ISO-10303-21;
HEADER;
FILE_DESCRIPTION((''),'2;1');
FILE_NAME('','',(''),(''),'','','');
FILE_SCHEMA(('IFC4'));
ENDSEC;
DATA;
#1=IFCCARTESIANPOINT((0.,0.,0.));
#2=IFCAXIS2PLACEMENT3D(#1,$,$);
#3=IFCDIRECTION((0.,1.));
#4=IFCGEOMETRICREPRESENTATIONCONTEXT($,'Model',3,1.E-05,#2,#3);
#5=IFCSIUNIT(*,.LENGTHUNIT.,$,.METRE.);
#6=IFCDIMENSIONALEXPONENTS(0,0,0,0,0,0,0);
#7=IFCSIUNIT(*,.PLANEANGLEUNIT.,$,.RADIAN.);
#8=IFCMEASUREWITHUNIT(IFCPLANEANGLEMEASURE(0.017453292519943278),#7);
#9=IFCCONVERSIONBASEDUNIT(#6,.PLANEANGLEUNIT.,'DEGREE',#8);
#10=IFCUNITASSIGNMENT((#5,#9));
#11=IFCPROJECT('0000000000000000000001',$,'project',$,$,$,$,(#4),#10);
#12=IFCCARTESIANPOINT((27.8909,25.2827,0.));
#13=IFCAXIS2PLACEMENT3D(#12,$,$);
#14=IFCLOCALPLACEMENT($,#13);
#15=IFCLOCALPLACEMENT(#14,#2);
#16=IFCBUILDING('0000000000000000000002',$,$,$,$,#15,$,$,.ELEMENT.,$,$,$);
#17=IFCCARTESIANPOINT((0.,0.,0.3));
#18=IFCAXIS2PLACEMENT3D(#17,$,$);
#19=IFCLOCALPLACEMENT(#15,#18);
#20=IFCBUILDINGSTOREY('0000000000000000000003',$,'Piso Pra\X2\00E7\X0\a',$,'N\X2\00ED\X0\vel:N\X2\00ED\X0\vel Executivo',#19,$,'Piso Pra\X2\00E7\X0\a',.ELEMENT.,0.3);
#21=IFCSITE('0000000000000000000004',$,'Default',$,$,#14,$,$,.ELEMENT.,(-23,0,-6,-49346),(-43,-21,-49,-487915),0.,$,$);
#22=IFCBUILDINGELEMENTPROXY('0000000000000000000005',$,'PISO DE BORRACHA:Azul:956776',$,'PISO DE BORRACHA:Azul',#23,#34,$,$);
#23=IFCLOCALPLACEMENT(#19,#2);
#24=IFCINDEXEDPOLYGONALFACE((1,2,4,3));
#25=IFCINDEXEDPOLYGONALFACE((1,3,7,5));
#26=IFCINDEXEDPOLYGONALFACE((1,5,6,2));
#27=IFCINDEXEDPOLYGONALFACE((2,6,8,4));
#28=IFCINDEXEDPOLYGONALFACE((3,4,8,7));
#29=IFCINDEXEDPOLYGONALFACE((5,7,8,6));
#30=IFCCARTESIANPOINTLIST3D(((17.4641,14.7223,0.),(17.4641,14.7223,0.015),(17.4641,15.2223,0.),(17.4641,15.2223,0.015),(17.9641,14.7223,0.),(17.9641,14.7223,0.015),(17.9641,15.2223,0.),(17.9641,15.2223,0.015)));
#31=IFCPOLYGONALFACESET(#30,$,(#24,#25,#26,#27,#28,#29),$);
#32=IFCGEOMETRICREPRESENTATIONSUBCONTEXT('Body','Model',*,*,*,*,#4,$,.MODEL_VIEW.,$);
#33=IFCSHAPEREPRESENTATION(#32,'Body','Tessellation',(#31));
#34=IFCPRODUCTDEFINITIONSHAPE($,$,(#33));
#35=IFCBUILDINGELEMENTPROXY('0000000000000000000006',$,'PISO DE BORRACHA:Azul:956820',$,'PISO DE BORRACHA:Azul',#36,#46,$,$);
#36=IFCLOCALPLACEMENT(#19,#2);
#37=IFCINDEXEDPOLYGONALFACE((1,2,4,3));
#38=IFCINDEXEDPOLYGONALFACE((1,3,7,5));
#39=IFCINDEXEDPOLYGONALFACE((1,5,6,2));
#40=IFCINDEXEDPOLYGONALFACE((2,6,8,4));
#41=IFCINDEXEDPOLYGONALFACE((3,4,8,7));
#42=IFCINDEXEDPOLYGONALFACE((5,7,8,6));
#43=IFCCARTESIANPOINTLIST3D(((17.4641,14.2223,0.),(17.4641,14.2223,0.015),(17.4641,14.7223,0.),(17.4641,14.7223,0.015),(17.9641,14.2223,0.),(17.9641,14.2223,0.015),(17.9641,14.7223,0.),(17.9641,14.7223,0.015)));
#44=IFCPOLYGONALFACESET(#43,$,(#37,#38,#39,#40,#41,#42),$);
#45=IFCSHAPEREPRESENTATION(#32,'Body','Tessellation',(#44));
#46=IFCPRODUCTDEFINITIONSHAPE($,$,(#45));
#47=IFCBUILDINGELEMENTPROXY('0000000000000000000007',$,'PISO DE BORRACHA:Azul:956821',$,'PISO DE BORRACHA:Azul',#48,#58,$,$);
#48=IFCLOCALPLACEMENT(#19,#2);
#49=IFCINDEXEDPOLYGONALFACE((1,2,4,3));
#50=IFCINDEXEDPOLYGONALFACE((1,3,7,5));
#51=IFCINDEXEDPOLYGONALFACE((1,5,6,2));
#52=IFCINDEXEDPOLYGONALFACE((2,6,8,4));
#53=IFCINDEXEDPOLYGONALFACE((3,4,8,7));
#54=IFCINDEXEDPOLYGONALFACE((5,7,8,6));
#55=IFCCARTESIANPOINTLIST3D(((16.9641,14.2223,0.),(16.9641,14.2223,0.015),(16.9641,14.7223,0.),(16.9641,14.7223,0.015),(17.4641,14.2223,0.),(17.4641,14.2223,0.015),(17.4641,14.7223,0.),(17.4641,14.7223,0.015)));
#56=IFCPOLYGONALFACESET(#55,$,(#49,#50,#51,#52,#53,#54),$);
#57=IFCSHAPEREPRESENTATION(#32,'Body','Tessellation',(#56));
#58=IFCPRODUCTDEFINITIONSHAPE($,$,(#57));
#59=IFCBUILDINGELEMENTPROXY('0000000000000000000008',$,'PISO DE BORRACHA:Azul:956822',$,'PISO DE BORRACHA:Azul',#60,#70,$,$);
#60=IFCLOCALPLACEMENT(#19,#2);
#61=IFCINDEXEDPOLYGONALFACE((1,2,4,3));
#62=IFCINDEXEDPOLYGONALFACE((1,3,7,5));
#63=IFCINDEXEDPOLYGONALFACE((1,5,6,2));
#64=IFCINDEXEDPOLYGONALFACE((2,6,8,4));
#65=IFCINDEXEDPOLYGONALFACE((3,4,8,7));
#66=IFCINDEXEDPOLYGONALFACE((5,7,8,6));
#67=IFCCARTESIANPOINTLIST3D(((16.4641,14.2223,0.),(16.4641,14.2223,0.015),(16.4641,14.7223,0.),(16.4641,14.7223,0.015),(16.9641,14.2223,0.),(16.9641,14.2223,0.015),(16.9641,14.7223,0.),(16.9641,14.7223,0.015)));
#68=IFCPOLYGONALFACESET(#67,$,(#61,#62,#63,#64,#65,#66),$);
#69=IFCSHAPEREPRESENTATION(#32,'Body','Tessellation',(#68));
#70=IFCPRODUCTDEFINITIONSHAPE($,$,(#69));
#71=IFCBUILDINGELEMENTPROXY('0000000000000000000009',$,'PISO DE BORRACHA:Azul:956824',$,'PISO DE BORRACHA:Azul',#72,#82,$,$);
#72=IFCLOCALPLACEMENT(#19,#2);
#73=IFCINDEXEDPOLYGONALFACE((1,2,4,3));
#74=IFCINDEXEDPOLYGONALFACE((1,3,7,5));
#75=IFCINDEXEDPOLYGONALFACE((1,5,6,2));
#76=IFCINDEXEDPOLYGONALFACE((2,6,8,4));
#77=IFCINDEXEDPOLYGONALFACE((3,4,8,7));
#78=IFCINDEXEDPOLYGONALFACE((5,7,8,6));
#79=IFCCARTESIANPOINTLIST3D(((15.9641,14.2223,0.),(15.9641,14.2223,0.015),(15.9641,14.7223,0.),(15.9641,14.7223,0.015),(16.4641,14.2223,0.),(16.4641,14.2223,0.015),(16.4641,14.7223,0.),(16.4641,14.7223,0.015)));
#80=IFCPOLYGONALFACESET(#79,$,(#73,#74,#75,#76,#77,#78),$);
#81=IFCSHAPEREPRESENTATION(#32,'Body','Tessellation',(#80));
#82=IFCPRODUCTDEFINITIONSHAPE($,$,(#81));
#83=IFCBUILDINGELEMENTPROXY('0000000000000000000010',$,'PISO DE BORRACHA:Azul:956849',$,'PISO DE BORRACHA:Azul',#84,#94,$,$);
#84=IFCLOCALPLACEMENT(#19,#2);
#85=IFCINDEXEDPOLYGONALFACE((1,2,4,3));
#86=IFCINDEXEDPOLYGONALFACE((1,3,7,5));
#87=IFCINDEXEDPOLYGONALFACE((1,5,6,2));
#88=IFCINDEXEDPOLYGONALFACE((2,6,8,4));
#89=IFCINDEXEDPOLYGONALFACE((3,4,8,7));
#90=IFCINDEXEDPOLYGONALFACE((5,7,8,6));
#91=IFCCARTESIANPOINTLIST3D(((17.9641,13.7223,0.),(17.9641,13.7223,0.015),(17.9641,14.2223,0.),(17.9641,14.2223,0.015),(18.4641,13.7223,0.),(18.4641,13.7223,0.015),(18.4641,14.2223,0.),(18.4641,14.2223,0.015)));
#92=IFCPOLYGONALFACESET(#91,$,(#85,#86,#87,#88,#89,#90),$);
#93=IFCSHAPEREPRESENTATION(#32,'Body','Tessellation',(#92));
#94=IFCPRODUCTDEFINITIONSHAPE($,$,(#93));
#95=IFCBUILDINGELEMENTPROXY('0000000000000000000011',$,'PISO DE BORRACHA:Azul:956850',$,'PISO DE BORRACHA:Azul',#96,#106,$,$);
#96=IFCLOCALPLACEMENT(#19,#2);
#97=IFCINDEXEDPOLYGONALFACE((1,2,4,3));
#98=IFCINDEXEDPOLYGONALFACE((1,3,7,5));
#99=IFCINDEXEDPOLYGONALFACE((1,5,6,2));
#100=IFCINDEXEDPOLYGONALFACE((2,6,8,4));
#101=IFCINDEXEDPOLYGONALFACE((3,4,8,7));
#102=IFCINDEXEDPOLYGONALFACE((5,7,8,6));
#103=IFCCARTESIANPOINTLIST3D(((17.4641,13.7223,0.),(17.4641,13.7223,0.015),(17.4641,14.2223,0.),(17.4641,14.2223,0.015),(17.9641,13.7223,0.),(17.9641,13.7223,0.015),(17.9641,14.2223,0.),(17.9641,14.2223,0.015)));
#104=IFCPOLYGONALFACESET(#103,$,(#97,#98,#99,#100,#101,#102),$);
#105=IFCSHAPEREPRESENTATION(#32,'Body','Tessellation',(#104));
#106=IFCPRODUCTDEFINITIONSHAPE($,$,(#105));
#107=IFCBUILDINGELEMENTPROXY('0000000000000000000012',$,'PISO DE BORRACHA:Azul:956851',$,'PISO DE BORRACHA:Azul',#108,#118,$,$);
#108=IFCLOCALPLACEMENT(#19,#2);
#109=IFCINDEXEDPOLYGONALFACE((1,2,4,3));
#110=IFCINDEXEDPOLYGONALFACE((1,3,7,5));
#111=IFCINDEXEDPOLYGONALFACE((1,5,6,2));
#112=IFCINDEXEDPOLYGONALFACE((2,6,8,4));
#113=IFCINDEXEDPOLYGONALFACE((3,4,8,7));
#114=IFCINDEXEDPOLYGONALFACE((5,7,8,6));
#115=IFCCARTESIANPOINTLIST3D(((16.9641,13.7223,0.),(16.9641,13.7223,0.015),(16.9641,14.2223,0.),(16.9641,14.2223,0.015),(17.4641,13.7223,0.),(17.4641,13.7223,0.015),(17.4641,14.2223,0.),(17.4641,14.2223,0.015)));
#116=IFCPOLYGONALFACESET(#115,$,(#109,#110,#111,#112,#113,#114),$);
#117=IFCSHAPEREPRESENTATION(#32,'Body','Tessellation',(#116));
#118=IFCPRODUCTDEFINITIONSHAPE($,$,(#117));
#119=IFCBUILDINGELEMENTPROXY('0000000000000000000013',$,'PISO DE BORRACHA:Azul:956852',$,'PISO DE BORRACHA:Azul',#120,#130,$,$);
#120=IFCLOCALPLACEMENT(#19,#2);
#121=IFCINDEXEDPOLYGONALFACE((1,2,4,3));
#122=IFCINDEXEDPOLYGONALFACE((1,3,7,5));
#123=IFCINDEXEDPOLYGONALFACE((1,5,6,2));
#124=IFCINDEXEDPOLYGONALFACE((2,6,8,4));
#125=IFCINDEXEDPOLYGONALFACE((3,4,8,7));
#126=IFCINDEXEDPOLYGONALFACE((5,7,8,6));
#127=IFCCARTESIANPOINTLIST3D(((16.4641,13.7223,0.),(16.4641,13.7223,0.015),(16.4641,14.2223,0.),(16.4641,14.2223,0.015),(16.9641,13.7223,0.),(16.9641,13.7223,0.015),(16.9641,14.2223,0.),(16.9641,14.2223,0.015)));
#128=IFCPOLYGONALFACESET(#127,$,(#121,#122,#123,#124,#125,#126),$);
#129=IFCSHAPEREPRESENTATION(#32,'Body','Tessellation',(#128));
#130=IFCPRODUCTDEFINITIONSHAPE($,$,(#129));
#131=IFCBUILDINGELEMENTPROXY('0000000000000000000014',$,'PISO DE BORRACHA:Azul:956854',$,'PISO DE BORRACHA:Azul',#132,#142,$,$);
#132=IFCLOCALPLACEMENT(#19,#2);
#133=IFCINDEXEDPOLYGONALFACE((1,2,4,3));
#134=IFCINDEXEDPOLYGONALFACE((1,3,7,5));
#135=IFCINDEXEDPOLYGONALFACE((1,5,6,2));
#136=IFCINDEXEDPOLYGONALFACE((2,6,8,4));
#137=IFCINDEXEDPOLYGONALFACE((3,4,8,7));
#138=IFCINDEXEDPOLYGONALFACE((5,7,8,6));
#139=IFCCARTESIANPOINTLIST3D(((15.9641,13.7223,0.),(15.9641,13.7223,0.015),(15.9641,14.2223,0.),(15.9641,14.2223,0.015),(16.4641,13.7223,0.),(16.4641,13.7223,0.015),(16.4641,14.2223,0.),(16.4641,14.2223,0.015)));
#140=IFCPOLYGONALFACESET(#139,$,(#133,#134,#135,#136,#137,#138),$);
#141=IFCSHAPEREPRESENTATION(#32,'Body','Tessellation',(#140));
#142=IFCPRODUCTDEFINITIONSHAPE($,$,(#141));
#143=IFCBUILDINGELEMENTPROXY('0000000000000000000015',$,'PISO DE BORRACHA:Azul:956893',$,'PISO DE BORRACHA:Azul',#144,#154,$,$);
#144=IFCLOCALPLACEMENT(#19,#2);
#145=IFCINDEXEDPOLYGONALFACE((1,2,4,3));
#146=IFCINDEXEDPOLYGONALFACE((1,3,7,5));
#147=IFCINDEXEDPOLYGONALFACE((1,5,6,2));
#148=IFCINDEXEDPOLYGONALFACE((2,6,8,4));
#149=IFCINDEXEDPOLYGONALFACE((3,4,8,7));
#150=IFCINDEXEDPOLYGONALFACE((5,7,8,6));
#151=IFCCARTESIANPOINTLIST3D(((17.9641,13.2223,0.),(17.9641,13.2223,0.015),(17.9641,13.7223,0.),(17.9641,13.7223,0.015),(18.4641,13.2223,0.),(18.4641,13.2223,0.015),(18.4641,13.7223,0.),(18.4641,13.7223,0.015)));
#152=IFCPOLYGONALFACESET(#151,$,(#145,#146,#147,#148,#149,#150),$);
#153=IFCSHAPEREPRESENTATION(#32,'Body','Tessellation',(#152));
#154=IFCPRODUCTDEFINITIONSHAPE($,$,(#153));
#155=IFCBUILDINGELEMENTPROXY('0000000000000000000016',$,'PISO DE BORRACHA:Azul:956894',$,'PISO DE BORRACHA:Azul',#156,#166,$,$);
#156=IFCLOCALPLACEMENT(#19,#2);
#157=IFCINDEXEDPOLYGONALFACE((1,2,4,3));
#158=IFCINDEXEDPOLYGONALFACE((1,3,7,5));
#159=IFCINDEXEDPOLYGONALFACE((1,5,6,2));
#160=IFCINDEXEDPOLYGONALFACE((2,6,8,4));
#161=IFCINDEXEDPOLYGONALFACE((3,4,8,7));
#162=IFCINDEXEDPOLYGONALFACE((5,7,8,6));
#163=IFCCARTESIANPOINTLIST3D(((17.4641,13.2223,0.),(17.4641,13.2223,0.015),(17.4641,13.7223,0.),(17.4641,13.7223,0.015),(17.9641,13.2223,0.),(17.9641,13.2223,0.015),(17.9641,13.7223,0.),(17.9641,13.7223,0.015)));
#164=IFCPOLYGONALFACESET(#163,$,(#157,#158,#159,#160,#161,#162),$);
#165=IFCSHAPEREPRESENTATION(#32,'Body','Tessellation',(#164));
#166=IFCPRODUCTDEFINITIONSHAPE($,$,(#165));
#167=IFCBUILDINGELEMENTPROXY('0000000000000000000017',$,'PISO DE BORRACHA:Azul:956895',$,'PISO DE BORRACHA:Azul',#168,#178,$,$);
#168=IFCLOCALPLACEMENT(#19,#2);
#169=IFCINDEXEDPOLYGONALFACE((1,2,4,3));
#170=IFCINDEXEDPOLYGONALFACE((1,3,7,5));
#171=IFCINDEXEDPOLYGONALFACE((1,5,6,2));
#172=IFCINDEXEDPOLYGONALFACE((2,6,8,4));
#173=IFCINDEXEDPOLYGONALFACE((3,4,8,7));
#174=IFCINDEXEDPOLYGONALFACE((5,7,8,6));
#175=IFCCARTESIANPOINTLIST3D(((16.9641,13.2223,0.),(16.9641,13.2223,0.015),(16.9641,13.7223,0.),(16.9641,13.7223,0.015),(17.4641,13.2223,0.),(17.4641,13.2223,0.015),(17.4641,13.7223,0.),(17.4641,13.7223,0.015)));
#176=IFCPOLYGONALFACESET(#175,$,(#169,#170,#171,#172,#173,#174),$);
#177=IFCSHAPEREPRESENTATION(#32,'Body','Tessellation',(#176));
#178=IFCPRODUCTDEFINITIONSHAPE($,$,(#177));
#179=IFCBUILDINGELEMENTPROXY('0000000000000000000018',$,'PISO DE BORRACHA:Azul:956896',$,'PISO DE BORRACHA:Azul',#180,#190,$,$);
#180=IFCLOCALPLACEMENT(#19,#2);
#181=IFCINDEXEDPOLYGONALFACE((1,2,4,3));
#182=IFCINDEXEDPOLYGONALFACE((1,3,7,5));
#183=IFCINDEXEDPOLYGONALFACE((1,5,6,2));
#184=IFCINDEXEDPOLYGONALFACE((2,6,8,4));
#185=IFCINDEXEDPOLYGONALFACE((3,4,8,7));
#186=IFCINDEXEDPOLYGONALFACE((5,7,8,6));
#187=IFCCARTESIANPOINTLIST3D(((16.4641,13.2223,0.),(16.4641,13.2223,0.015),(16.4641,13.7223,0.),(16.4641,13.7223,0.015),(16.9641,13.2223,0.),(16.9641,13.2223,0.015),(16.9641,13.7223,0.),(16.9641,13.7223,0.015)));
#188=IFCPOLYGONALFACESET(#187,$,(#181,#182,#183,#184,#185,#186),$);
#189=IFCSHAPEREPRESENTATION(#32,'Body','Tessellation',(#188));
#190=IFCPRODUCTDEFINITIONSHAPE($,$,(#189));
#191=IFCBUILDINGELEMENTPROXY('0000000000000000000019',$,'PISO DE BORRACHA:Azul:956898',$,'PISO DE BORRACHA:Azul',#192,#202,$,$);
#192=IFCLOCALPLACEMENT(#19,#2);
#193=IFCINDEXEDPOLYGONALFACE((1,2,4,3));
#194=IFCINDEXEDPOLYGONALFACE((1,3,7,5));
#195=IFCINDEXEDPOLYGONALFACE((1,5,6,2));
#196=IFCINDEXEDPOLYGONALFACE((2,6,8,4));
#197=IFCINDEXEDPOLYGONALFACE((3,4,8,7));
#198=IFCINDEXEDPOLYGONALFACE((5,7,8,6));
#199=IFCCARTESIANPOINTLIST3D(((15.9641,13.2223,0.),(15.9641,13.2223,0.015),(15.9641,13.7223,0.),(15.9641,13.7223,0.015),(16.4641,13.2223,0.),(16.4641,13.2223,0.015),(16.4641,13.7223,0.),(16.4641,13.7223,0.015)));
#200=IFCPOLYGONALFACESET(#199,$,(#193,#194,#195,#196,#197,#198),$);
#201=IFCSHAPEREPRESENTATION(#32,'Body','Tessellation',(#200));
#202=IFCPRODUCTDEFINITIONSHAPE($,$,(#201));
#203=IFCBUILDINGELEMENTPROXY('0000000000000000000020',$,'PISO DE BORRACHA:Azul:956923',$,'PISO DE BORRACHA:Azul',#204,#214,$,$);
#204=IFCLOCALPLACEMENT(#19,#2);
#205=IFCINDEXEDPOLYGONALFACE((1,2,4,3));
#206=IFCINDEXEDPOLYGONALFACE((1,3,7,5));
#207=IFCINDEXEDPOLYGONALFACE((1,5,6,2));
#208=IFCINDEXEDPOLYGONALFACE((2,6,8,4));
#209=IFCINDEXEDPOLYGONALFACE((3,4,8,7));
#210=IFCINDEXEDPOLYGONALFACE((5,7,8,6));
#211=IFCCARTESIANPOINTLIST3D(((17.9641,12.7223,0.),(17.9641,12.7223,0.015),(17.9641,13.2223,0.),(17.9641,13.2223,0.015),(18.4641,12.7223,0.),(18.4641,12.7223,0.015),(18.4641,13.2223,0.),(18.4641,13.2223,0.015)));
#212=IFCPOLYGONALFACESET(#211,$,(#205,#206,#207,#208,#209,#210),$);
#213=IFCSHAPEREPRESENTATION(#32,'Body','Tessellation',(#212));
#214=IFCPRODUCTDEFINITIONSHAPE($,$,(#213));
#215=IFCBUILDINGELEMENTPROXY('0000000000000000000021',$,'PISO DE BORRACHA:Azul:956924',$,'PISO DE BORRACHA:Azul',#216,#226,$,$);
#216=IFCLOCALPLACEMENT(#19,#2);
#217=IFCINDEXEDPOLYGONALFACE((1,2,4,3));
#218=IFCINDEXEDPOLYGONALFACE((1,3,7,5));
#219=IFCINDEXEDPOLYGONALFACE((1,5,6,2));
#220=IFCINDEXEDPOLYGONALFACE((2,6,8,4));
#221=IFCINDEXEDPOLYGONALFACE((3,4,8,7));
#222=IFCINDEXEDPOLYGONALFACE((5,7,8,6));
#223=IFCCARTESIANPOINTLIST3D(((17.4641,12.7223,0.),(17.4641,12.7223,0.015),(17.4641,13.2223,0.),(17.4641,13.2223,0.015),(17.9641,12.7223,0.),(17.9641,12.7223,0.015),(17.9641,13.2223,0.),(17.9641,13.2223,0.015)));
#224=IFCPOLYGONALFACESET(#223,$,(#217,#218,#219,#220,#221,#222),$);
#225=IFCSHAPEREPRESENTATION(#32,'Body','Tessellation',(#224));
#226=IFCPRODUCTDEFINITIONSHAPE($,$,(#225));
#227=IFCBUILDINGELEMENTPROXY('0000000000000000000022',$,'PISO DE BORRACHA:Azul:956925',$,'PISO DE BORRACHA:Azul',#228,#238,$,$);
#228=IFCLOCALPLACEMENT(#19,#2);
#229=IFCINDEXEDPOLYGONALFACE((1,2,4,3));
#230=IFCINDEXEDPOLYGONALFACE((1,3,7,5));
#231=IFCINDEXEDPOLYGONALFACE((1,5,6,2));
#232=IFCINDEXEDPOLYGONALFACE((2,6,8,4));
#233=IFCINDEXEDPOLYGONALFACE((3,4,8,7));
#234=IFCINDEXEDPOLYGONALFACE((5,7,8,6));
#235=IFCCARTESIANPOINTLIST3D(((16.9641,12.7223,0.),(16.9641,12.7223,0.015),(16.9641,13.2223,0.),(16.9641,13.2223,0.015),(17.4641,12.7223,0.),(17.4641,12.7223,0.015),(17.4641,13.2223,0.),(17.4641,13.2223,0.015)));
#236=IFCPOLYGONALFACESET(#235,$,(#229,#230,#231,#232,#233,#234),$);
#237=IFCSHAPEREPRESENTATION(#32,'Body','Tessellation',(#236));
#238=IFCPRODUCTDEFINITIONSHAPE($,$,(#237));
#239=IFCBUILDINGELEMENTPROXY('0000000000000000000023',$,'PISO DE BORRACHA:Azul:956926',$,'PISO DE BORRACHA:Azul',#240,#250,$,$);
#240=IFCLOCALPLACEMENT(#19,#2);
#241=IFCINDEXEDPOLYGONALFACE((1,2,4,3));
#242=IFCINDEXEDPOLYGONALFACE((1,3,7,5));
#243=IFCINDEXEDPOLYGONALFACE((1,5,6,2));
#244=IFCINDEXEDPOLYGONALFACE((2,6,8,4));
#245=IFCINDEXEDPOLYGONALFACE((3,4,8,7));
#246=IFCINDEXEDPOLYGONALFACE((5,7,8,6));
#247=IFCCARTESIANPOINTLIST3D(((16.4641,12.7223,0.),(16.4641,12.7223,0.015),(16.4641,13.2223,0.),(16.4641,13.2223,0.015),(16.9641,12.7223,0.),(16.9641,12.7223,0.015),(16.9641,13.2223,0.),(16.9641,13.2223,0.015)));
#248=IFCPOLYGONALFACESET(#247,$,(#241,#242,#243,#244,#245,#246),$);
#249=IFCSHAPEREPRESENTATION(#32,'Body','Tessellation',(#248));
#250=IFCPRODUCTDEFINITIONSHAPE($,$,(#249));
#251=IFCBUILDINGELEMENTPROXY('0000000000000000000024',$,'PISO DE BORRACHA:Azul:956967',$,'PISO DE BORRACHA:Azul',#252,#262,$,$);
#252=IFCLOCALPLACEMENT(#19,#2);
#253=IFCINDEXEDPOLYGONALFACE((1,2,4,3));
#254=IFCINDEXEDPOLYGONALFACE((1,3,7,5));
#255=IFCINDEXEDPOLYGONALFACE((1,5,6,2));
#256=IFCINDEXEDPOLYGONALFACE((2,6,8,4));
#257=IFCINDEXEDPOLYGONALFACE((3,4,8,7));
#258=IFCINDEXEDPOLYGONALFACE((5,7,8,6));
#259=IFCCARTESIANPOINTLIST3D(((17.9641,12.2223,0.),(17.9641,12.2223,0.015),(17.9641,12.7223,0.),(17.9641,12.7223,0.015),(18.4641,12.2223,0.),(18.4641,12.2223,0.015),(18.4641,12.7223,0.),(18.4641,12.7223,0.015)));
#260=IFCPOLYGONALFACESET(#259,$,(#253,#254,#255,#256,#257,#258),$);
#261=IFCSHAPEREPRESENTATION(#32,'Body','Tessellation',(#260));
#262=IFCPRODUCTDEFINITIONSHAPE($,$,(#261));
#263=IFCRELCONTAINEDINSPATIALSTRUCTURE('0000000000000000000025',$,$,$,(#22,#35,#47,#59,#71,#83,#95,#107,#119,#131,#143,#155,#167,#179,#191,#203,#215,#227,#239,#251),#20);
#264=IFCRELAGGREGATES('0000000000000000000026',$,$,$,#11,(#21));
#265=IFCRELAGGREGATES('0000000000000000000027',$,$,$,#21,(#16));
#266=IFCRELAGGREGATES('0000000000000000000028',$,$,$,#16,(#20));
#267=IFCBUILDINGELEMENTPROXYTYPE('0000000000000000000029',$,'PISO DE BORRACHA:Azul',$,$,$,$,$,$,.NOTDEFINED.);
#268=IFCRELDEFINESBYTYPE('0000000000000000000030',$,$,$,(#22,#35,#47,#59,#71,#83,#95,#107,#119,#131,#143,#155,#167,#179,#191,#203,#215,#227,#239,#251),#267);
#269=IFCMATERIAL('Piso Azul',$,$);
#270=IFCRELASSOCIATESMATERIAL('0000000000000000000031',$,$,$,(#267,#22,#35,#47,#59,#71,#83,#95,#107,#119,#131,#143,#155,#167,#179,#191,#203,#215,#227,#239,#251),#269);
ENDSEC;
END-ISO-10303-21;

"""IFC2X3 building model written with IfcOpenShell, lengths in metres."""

from ifc_helpers import new_model, entity, si_unit, converted_unit, direction, frame, origin, origin_2d_with_axis, place, context, subcontext, project, spatial, rectangle, extrude, source, transform, mapped, material, type_object, type_shapes, element, save


model = new_model("IFC2X3")

# Units and contexts
model_context = context("Model", 3, precision=1e-05, world=origin(), true_north=direction((0.0, 1.0)))
body_context = subcontext(model_context, "Body", "Model", "MODEL_VIEW")
ifc_project = project(units=[si_unit("LENGTHUNIT", "METRE"), converted_unit("PLANEANGLEUNIT", "DEGREE", entity("IfcPlaneAngleMeasure", 0.017453292519943278), si_unit("PLANEANGLEUNIT", "RADIAN"), dimensions=[0, 0, 0, 0, 0, 0, 0])], contexts=[model_context])

# Site, building, storey
site_placement = place(None, frame((27.8909, 25.2827, 0.0)))
site = spatial("IfcSite", under=ifc_project, at=site_placement, Name="Default", CompositionType="ELEMENT", RefLatitude=(-23, 0, -6, -49346), RefLongitude=(-43, -21, -49, -487915), RefElevation=0.0)
building_placement = place(site_placement, origin())
building = spatial("IfcBuilding", under=site, at=building_placement, CompositionType="ELEMENT")
storey_placement = place(building_placement, frame((0.0, 0.0, 0.3)))
storey = spatial("IfcBuildingStorey", under=building, at=storey_placement, Name="Piso Praça", ObjectType="Nível:Nível Executivo", LongName="Piso Praça", CompositionType="ELEMENT", Elevation=0.3)

# Building element proxies
ifc_material = material(Name="Piso Azul")
building_element_proxy_type = type_object("IfcBuildingElementProxyType", Name="PISO DE BORRACHA:Azul", PredefinedType="NOTDEFINED", material=ifc_material)
shared_shape = source(origin(), body_context, "Body", "SweptSolid", [
    extrude(rectangle(XDim=0.5, YDim=0.5, at=origin_2d_with_axis()), frame((0.25, 0.25, 0.0), z_axis=(0.0, 0.0, 1.0), x_axis=(-1.0, 0.0, 0.0)), (0.0, 0.0, 1.0), 0.015),
])
type_shapes(building_element_proxy_type, [shared_shape])
for number, where, name in (
    (1, (17.4641, 14.7223, 0.0), "PISO DE BORRACHA:Azul:956776"),
    (2, (17.4641, 14.2223, 0.0), "PISO DE BORRACHA:Azul:956820"),
    (3, (16.9641, 14.2223, 0.0), "PISO DE BORRACHA:Azul:956821"),
    (4, (16.4641, 14.2223, 0.0), "PISO DE BORRACHA:Azul:956822"),
    (5, (15.9641, 14.2223, 0.0), "PISO DE BORRACHA:Azul:956824"),
    (6, (17.9641, 13.7223, 0.0), "PISO DE BORRACHA:Azul:956849"),
    (7, (17.4641, 13.7223, 0.0), "PISO DE BORRACHA:Azul:956850"),
    (8, (16.9641, 13.7223, 0.0), "PISO DE BORRACHA:Azul:956851"),
    (9, (16.4641, 13.7223, 0.0), "PISO DE BORRACHA:Azul:956852"),
    (10, (15.9641, 13.7223, 0.0), "PISO DE BORRACHA:Azul:956854"),
    (11, (17.9641, 13.2223, 0.0), "PISO DE BORRACHA:Azul:956893"),
    (12, (17.4641, 13.2223, 0.0), "PISO DE BORRACHA:Azul:956894"),
    (13, (16.9641, 13.2223, 0.0), "PISO DE BORRACHA:Azul:956895"),
    (14, (16.4641, 13.2223, 0.0), "PISO DE BORRACHA:Azul:956896"),
    (15, (15.9641, 13.2223, 0.0), "PISO DE BORRACHA:Azul:956898"),
    (16, (17.9641, 12.7223, 0.0), "PISO DE BORRACHA:Azul:956923"),
    (17, (17.4641, 12.7223, 0.0), "PISO DE BORRACHA:Azul:956924"),
    (18, (16.9641, 12.7223, 0.0), "PISO DE BORRACHA:Azul:956925"),
    (19, (16.4641, 12.7223, 0.0), "PISO DE BORRACHA:Azul:956926"),
    (20, (17.9641, 12.2223, 0.0), "PISO DE BORRACHA:Azul:956967"),
):
    element("IfcBuildingElementProxy", number, at=place(storey_placement, frame(where)), inside=storey, type_object=building_element_proxy_type, material=ifc_material, Name=name, ObjectType="PISO DE BORRACHA:Azul", context=body_context, shape_type="MappedRepresentation", body=[
        mapped(shared_shape, transform((0.0, 0.0, 0.0), scale=1.0)),
    ])

save(model, "model.ifc")
